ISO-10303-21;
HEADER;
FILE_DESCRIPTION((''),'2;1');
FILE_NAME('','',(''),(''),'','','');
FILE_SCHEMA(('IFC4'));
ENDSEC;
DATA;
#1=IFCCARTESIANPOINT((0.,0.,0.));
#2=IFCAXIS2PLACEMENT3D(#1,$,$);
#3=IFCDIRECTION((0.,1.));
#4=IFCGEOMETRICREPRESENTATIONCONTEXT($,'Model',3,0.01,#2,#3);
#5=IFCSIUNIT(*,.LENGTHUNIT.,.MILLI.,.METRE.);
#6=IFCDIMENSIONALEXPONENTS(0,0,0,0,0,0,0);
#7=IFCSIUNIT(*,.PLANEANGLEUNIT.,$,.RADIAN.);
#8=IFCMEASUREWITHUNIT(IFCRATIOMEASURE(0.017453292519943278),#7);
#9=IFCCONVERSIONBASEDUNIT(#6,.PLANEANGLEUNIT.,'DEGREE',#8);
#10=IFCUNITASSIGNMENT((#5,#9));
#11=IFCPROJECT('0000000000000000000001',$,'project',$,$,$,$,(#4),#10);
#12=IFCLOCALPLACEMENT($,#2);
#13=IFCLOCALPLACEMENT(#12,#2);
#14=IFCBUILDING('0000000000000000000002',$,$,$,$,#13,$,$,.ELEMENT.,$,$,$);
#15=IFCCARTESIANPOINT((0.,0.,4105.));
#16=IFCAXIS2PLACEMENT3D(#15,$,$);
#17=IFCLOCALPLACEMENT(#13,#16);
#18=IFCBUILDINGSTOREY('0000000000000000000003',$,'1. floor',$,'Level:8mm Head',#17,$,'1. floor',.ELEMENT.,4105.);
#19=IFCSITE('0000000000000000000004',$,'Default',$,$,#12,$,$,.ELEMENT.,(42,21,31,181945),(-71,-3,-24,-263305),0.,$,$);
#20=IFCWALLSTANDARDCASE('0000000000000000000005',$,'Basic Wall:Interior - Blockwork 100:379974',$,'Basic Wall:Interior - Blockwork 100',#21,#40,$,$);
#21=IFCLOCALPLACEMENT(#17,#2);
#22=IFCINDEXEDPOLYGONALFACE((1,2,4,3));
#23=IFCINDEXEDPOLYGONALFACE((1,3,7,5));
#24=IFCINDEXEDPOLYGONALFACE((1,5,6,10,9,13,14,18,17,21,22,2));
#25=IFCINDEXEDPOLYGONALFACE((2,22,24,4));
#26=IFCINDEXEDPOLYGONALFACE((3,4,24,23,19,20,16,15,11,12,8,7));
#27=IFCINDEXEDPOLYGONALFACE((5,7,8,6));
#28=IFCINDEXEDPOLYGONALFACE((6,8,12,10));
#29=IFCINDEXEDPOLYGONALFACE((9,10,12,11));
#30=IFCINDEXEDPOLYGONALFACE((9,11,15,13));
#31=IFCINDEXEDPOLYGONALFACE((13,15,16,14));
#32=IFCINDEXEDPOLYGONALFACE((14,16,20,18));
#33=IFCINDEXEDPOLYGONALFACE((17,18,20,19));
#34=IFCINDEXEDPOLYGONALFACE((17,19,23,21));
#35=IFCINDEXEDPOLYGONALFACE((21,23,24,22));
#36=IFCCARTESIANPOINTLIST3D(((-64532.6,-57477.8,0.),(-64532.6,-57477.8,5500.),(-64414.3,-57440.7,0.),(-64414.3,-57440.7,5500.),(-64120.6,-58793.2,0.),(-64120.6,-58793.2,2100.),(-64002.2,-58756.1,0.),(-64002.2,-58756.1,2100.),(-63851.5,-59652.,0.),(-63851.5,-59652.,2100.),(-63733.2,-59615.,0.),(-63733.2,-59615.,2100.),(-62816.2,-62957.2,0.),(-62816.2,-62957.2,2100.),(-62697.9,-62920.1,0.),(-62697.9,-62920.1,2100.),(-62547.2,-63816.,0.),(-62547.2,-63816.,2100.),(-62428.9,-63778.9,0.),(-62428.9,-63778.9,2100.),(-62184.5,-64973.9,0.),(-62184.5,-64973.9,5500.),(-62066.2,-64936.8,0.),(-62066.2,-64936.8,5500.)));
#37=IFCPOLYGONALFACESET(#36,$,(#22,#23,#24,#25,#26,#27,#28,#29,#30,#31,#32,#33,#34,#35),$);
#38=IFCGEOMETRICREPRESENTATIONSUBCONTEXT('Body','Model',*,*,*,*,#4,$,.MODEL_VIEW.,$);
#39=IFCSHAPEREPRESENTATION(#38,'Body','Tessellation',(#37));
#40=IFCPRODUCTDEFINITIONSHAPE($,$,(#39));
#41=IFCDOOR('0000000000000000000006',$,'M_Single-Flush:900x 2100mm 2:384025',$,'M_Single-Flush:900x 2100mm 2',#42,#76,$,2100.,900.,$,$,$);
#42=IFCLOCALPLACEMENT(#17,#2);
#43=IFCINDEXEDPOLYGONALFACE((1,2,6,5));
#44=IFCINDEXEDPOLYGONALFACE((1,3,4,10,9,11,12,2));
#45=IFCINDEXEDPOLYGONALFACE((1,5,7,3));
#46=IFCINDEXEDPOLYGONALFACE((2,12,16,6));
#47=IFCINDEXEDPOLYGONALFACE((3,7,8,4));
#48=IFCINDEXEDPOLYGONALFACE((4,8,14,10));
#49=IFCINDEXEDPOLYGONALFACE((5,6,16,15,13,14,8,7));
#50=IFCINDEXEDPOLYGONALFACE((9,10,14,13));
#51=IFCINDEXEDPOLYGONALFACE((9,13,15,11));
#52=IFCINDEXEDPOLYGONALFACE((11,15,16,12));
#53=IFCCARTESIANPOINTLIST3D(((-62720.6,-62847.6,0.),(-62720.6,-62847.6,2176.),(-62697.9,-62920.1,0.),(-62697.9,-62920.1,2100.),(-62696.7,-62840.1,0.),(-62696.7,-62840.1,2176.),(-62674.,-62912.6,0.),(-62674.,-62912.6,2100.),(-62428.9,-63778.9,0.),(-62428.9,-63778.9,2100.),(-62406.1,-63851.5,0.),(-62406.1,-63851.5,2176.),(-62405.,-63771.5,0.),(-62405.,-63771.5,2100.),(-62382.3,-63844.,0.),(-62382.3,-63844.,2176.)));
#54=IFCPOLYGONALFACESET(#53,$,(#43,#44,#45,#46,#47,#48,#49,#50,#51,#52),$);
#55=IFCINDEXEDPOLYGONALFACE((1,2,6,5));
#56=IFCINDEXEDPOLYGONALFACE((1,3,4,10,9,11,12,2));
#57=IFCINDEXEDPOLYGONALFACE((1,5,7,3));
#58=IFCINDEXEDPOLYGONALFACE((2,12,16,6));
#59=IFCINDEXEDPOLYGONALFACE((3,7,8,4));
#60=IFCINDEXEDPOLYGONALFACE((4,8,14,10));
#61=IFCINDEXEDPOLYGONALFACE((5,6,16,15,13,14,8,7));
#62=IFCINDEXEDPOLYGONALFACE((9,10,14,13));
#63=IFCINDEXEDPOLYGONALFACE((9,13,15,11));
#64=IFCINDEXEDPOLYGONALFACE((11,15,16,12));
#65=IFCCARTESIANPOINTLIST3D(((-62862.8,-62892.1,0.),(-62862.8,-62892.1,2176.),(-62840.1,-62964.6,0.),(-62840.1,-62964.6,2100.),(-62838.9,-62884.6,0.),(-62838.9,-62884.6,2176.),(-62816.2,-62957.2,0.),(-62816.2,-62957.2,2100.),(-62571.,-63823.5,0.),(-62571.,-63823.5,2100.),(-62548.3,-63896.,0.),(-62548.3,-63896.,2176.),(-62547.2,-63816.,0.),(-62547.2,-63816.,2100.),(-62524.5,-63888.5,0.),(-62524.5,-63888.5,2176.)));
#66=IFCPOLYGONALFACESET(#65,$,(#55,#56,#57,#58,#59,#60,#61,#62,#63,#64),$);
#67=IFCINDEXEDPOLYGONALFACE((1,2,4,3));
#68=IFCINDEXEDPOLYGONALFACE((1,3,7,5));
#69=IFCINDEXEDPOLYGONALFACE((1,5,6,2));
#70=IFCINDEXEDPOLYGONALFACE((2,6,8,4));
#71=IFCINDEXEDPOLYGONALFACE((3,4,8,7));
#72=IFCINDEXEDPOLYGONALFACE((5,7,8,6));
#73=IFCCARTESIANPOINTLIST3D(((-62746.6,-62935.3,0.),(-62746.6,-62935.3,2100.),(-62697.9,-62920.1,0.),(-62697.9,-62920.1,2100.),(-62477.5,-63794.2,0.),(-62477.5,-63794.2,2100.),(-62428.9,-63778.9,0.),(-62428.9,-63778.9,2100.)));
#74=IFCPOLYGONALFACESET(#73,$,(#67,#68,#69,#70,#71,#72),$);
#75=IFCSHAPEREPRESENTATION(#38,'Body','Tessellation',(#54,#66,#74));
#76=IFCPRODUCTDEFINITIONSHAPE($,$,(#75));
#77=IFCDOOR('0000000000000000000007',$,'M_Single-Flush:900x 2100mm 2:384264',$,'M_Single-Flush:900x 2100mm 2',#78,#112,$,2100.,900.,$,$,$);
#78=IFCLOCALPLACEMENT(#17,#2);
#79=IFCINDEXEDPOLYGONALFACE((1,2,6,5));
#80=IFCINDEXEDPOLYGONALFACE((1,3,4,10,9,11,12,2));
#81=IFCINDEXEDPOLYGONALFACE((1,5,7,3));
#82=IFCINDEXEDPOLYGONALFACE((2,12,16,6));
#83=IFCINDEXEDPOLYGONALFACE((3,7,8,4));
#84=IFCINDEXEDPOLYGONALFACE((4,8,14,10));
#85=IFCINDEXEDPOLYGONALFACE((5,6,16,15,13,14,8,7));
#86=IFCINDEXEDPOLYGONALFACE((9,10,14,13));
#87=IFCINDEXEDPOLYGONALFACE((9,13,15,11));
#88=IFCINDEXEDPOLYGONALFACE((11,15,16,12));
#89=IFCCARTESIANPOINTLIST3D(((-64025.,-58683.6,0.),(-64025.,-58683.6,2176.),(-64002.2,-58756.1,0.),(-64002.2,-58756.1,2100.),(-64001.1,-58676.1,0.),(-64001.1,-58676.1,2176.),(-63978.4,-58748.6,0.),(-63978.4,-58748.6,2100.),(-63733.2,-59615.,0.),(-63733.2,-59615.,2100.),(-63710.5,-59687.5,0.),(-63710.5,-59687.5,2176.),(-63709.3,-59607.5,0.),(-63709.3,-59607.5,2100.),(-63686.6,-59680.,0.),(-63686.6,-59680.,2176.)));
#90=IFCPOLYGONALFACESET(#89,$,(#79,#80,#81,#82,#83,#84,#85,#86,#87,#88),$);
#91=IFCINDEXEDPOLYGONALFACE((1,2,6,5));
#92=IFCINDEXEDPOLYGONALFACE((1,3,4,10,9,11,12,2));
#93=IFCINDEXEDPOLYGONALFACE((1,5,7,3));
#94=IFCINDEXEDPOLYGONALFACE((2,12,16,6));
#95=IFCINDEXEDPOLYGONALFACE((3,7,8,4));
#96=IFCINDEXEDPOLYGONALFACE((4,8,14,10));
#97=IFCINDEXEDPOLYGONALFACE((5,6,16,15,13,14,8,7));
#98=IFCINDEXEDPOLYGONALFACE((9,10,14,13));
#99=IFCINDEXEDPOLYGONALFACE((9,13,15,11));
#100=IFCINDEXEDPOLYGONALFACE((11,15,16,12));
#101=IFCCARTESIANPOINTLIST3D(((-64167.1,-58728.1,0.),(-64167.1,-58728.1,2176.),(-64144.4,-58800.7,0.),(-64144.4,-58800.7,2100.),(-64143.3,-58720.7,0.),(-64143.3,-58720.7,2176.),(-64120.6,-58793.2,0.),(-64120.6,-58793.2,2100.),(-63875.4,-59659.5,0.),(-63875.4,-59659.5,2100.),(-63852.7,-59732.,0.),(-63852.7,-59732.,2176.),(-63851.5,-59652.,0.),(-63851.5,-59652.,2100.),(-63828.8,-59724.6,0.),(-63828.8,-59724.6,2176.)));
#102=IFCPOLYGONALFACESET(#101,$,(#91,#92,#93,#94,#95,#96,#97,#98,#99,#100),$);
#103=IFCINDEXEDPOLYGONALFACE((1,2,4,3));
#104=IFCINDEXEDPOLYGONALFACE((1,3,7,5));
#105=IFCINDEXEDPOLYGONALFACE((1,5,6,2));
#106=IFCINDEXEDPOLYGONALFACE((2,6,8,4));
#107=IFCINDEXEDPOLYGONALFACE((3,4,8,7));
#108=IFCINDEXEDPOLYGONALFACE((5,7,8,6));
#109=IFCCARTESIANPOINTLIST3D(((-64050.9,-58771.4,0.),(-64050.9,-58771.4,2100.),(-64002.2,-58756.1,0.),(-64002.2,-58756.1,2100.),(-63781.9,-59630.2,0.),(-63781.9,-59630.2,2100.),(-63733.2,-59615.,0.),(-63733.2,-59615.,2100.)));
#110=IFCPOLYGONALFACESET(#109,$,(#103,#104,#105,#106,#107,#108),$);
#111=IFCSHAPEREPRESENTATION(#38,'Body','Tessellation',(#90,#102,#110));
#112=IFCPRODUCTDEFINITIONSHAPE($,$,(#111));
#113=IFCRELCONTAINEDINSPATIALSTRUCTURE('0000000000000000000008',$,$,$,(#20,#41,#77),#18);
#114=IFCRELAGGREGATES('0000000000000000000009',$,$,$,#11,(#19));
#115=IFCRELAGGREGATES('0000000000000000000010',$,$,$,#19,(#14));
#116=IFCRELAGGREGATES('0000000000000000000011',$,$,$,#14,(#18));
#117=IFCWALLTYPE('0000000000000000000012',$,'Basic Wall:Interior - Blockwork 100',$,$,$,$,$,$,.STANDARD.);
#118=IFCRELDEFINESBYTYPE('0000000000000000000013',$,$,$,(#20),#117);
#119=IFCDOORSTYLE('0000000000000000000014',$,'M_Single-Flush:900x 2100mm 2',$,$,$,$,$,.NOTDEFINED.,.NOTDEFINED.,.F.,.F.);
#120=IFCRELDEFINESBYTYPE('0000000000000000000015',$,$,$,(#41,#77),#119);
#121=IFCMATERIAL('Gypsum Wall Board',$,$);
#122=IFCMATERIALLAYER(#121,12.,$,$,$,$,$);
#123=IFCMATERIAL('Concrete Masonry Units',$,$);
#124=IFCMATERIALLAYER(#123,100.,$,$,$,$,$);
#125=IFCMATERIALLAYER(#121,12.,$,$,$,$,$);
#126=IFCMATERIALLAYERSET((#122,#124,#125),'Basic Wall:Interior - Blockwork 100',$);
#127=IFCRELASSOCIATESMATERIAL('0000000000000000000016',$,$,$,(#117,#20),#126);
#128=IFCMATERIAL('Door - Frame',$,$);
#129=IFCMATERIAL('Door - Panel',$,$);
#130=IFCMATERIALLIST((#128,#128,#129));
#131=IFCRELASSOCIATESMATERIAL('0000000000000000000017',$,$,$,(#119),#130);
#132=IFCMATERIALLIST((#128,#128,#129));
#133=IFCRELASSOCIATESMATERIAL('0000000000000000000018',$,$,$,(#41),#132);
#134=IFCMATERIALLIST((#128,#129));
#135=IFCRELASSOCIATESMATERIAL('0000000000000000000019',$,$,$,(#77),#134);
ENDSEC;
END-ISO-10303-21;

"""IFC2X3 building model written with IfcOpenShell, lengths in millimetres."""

from ifc_helpers import new_model, entity, si_unit, converted_unit, direction, frame, frame_2d, origin, origin_2d_with_axis, place, context, subcontext, project, spatial, polyline, rectangle, outline, extrude, source, transform, mapped, material, material_list, layer, layer_set, layer_usage, type_object, type_shapes, element, fill, save


model = new_model("IFC2X3")

# Units and contexts
model_context = context("Model", 3, precision=0.01, world=origin(), true_north=direction((0.0, 1.0)))
body_context = subcontext(model_context, "Body", "Model", "MODEL_VIEW")
ifc_project = project(units=[si_unit("LENGTHUNIT", "METRE", prefix="MILLI"), converted_unit("PLANEANGLEUNIT", "DEGREE", entity("IfcRatioMeasure", 0.017453292519943278), si_unit("PLANEANGLEUNIT", "RADIAN"), dimensions=[0, 0, 0, 0, 0, 0, 0])], contexts=[model_context])

# Site, building, storey
site_placement = place(None, origin())
site = spatial("IfcSite", under=ifc_project, at=site_placement, Name="Default", CompositionType="ELEMENT", RefLatitude=(42, 21, 31, 181945), RefLongitude=(-71, -3, -24, -263305), RefElevation=0.0)
building_placement = place(site_placement, origin())
building = spatial("IfcBuilding", under=site, at=building_placement, CompositionType="ELEMENT")
storey_placement = place(building_placement, frame((0.0, 0.0, 4105.0)))
storey = spatial("IfcBuildingStorey", under=building, at=storey_placement, Name="1. floor", ObjectType="Level:8mm Head", LongName="1. floor", CompositionType="ELEMENT", Elevation=4105.0)

# Shared definitions
ifc_material_1 = material(Name="Gypsum Wall Board")

# Shared definitions
ifc_layer_1 = layer(ifc_material_1, 12.0)
ifc_material_2 = material(Name="Concrete Masonry Units")
ifc_layer_2 = layer(ifc_material_2, 100.0)
ifc_layer_3 = layer(ifc_material_1, 12.0)
ifc_layer_set_1 = layer_set([ifc_layer_1, ifc_layer_2, ifc_layer_3], Name="Basic Wall:Interior - Blockwork 100")
wall_type_1 = type_object("IfcWallType", Name="Basic Wall:Interior - Blockwork 100", PredefinedType="STANDARD", material=ifc_layer_set_1)
ifc_material_3 = material(Name="Door - Frame")
ifc_material_4 = material(Name="Door - Panel")
ifc_material_list_1 = material_list([ifc_material_3, ifc_material_3, ifc_material_4])
door_style_1 = type_object("IfcDoorStyle", Name="M_Single-Flush:900x 2100mm 2", ConstructionType="NOTDEFINED", OperationType="NOTDEFINED", ParameterTakesPrecedence=False, Sizeable=False, material=ifc_material_list_1)
shared_shape_1 = source(origin(), body_context, "Body", "SweptSolid", [
    extrude(outline(polyline([(-526.0, -1107.0), (526.0, -1107.0), (526.0, 1069.0), (450.0, 1069.0), (450.0, -1031.0), (-450.0, -1031.0), (-450.0, 1069.0), (-526.0, 1069.0), (-526.0, -1107.0)])), frame((450.0, 124.0, 1069.0), z_axis=(0.0, 1.0, 0.0), x_axis=(1.0, 0.0, 0.0)), (0.0, 0.0, 1.0), 25.0),
    extrude(outline(polyline([(-1107.0, -526.0), (1069.0, -526.0), (1069.0, -450.0), (-1031.0, -450.0), (-1031.0, 450.0), (1069.0, 450.0), (1069.0, 526.0), (-1107.0, 526.0), (-1107.0, -526.0)])), frame((450.0, -25.0, 1069.0), z_axis=(0.0, 1.0, 0.0), x_axis=(0.0, 0.0, -1.0)), (0.0, 0.0, 1.0), 25.0),
    extrude(rectangle(XDim=51.0, YDim=900.0, at=origin_2d_with_axis()), frame((450.0, 98.5, 0.0), z_axis=(0.0, 0.0, 1.0), x_axis=(0.0, 1.0, 0.0)), (0.0, 0.0, 1.0), 2100.0),
])
type_shapes(door_style_1, [shared_shape_1])

# Wall, openings, doors
ifc_layer_usage_1 = layer_usage(ifc_layer_set_1, "AXIS2", "NEGATIVE", 62.0)
wall_1_placement = place(storey_placement, frame((-64473.4, -57459.3, 0.0), z_axis=(0.0, 0.0, 1.0), x_axis=(0.298924, -0.954277, 0.0)))
wall_1 = element("IfcWallStandardCase", 1, at=wall_1_placement, inside=storey, type_object=wall_type_1, material=ifc_layer_usage_1, Name="Basic Wall:Interior - Blockwork 100:379974", ObjectType="Basic Wall:Interior - Blockwork 100", context=body_context, shape_type="SweptSolid", body=[
    extrude(rectangle(XDim=7855.2, YDim=124.0, at=frame_2d((3927.6, 0.0), x_axis=(-1.0, 0.0))), origin(), (0.0, 0.0, 1.0), 5500.0),
])
opening_1_placement = place(wall_1_placement, frame((5741.9, -62.0, 0.0)))
opening_1 = element("IfcOpeningElement", 2, at=opening_1_placement, cuts=wall_1, ObjectType="Opening", context=body_context, shape_type="SweptSolid", body=[
    extrude(rectangle(XDim=900.0, YDim=2100.0, at=frame_2d((1050.0, 450.0), x_axis=(0.0, 1.0))), frame((0.0, 0.0, 0.0), z_axis=(0.0, 1.0, 0.0), x_axis=(0.0, 0.0, 1.0)), (0.0, 0.0, 1.0), 124.0),
])
opening_2_placement = place(wall_1_placement, frame((1378.4, -62.0, 0.0)))
opening_2 = element("IfcOpeningElement", 3, at=opening_2_placement, cuts=wall_1, ObjectType="Opening", context=body_context, shape_type="SweptSolid", body=[
    extrude(rectangle(XDim=900.0, YDim=2100.0, at=frame_2d((1050.0, 450.0), x_axis=(0.0, 1.0))), frame((0.0, 0.0, 0.0), z_axis=(0.0, 1.0, 0.0), x_axis=(0.0, 0.0, 1.0)), (0.0, 0.0, 1.0), 124.0),
])
ifc_material_list_2 = material_list([ifc_material_3, ifc_material_3, ifc_material_4])
door_1_placement = place(opening_1_placement, origin())
door_1 = element("IfcDoor", 4, at=door_1_placement, inside=storey, type_object=door_style_1, material=ifc_material_list_2, Name="M_Single-Flush:900x 2100mm 2:384025", ObjectType="M_Single-Flush:900x 2100mm 2", OverallHeight=2100.0, OverallWidth=900.0, context=body_context, shape_type="MappedRepresentation", body=[
    mapped(shared_shape_1, transform((0.0, 0.0, 0.0), scale=1.0)),
])
fill(opening_1, door_1)
ifc_material_list_3 = material_list([ifc_material_3, ifc_material_4])
door_2_placement = place(opening_2_placement, origin())
door_2 = element("IfcDoor", 5, at=door_2_placement, inside=storey, type_object=door_style_1, material=ifc_material_list_3, Name="M_Single-Flush:900x 2100mm 2:384264", ObjectType="M_Single-Flush:900x 2100mm 2", OverallHeight=2100.0, OverallWidth=900.0, context=body_context, shape_type="MappedRepresentation", body=[
    mapped(shared_shape_1, transform((0.0, 0.0, 0.0), scale=1.0)),
])
fill(opening_2, door_2)

save(model, "model.ifc")
